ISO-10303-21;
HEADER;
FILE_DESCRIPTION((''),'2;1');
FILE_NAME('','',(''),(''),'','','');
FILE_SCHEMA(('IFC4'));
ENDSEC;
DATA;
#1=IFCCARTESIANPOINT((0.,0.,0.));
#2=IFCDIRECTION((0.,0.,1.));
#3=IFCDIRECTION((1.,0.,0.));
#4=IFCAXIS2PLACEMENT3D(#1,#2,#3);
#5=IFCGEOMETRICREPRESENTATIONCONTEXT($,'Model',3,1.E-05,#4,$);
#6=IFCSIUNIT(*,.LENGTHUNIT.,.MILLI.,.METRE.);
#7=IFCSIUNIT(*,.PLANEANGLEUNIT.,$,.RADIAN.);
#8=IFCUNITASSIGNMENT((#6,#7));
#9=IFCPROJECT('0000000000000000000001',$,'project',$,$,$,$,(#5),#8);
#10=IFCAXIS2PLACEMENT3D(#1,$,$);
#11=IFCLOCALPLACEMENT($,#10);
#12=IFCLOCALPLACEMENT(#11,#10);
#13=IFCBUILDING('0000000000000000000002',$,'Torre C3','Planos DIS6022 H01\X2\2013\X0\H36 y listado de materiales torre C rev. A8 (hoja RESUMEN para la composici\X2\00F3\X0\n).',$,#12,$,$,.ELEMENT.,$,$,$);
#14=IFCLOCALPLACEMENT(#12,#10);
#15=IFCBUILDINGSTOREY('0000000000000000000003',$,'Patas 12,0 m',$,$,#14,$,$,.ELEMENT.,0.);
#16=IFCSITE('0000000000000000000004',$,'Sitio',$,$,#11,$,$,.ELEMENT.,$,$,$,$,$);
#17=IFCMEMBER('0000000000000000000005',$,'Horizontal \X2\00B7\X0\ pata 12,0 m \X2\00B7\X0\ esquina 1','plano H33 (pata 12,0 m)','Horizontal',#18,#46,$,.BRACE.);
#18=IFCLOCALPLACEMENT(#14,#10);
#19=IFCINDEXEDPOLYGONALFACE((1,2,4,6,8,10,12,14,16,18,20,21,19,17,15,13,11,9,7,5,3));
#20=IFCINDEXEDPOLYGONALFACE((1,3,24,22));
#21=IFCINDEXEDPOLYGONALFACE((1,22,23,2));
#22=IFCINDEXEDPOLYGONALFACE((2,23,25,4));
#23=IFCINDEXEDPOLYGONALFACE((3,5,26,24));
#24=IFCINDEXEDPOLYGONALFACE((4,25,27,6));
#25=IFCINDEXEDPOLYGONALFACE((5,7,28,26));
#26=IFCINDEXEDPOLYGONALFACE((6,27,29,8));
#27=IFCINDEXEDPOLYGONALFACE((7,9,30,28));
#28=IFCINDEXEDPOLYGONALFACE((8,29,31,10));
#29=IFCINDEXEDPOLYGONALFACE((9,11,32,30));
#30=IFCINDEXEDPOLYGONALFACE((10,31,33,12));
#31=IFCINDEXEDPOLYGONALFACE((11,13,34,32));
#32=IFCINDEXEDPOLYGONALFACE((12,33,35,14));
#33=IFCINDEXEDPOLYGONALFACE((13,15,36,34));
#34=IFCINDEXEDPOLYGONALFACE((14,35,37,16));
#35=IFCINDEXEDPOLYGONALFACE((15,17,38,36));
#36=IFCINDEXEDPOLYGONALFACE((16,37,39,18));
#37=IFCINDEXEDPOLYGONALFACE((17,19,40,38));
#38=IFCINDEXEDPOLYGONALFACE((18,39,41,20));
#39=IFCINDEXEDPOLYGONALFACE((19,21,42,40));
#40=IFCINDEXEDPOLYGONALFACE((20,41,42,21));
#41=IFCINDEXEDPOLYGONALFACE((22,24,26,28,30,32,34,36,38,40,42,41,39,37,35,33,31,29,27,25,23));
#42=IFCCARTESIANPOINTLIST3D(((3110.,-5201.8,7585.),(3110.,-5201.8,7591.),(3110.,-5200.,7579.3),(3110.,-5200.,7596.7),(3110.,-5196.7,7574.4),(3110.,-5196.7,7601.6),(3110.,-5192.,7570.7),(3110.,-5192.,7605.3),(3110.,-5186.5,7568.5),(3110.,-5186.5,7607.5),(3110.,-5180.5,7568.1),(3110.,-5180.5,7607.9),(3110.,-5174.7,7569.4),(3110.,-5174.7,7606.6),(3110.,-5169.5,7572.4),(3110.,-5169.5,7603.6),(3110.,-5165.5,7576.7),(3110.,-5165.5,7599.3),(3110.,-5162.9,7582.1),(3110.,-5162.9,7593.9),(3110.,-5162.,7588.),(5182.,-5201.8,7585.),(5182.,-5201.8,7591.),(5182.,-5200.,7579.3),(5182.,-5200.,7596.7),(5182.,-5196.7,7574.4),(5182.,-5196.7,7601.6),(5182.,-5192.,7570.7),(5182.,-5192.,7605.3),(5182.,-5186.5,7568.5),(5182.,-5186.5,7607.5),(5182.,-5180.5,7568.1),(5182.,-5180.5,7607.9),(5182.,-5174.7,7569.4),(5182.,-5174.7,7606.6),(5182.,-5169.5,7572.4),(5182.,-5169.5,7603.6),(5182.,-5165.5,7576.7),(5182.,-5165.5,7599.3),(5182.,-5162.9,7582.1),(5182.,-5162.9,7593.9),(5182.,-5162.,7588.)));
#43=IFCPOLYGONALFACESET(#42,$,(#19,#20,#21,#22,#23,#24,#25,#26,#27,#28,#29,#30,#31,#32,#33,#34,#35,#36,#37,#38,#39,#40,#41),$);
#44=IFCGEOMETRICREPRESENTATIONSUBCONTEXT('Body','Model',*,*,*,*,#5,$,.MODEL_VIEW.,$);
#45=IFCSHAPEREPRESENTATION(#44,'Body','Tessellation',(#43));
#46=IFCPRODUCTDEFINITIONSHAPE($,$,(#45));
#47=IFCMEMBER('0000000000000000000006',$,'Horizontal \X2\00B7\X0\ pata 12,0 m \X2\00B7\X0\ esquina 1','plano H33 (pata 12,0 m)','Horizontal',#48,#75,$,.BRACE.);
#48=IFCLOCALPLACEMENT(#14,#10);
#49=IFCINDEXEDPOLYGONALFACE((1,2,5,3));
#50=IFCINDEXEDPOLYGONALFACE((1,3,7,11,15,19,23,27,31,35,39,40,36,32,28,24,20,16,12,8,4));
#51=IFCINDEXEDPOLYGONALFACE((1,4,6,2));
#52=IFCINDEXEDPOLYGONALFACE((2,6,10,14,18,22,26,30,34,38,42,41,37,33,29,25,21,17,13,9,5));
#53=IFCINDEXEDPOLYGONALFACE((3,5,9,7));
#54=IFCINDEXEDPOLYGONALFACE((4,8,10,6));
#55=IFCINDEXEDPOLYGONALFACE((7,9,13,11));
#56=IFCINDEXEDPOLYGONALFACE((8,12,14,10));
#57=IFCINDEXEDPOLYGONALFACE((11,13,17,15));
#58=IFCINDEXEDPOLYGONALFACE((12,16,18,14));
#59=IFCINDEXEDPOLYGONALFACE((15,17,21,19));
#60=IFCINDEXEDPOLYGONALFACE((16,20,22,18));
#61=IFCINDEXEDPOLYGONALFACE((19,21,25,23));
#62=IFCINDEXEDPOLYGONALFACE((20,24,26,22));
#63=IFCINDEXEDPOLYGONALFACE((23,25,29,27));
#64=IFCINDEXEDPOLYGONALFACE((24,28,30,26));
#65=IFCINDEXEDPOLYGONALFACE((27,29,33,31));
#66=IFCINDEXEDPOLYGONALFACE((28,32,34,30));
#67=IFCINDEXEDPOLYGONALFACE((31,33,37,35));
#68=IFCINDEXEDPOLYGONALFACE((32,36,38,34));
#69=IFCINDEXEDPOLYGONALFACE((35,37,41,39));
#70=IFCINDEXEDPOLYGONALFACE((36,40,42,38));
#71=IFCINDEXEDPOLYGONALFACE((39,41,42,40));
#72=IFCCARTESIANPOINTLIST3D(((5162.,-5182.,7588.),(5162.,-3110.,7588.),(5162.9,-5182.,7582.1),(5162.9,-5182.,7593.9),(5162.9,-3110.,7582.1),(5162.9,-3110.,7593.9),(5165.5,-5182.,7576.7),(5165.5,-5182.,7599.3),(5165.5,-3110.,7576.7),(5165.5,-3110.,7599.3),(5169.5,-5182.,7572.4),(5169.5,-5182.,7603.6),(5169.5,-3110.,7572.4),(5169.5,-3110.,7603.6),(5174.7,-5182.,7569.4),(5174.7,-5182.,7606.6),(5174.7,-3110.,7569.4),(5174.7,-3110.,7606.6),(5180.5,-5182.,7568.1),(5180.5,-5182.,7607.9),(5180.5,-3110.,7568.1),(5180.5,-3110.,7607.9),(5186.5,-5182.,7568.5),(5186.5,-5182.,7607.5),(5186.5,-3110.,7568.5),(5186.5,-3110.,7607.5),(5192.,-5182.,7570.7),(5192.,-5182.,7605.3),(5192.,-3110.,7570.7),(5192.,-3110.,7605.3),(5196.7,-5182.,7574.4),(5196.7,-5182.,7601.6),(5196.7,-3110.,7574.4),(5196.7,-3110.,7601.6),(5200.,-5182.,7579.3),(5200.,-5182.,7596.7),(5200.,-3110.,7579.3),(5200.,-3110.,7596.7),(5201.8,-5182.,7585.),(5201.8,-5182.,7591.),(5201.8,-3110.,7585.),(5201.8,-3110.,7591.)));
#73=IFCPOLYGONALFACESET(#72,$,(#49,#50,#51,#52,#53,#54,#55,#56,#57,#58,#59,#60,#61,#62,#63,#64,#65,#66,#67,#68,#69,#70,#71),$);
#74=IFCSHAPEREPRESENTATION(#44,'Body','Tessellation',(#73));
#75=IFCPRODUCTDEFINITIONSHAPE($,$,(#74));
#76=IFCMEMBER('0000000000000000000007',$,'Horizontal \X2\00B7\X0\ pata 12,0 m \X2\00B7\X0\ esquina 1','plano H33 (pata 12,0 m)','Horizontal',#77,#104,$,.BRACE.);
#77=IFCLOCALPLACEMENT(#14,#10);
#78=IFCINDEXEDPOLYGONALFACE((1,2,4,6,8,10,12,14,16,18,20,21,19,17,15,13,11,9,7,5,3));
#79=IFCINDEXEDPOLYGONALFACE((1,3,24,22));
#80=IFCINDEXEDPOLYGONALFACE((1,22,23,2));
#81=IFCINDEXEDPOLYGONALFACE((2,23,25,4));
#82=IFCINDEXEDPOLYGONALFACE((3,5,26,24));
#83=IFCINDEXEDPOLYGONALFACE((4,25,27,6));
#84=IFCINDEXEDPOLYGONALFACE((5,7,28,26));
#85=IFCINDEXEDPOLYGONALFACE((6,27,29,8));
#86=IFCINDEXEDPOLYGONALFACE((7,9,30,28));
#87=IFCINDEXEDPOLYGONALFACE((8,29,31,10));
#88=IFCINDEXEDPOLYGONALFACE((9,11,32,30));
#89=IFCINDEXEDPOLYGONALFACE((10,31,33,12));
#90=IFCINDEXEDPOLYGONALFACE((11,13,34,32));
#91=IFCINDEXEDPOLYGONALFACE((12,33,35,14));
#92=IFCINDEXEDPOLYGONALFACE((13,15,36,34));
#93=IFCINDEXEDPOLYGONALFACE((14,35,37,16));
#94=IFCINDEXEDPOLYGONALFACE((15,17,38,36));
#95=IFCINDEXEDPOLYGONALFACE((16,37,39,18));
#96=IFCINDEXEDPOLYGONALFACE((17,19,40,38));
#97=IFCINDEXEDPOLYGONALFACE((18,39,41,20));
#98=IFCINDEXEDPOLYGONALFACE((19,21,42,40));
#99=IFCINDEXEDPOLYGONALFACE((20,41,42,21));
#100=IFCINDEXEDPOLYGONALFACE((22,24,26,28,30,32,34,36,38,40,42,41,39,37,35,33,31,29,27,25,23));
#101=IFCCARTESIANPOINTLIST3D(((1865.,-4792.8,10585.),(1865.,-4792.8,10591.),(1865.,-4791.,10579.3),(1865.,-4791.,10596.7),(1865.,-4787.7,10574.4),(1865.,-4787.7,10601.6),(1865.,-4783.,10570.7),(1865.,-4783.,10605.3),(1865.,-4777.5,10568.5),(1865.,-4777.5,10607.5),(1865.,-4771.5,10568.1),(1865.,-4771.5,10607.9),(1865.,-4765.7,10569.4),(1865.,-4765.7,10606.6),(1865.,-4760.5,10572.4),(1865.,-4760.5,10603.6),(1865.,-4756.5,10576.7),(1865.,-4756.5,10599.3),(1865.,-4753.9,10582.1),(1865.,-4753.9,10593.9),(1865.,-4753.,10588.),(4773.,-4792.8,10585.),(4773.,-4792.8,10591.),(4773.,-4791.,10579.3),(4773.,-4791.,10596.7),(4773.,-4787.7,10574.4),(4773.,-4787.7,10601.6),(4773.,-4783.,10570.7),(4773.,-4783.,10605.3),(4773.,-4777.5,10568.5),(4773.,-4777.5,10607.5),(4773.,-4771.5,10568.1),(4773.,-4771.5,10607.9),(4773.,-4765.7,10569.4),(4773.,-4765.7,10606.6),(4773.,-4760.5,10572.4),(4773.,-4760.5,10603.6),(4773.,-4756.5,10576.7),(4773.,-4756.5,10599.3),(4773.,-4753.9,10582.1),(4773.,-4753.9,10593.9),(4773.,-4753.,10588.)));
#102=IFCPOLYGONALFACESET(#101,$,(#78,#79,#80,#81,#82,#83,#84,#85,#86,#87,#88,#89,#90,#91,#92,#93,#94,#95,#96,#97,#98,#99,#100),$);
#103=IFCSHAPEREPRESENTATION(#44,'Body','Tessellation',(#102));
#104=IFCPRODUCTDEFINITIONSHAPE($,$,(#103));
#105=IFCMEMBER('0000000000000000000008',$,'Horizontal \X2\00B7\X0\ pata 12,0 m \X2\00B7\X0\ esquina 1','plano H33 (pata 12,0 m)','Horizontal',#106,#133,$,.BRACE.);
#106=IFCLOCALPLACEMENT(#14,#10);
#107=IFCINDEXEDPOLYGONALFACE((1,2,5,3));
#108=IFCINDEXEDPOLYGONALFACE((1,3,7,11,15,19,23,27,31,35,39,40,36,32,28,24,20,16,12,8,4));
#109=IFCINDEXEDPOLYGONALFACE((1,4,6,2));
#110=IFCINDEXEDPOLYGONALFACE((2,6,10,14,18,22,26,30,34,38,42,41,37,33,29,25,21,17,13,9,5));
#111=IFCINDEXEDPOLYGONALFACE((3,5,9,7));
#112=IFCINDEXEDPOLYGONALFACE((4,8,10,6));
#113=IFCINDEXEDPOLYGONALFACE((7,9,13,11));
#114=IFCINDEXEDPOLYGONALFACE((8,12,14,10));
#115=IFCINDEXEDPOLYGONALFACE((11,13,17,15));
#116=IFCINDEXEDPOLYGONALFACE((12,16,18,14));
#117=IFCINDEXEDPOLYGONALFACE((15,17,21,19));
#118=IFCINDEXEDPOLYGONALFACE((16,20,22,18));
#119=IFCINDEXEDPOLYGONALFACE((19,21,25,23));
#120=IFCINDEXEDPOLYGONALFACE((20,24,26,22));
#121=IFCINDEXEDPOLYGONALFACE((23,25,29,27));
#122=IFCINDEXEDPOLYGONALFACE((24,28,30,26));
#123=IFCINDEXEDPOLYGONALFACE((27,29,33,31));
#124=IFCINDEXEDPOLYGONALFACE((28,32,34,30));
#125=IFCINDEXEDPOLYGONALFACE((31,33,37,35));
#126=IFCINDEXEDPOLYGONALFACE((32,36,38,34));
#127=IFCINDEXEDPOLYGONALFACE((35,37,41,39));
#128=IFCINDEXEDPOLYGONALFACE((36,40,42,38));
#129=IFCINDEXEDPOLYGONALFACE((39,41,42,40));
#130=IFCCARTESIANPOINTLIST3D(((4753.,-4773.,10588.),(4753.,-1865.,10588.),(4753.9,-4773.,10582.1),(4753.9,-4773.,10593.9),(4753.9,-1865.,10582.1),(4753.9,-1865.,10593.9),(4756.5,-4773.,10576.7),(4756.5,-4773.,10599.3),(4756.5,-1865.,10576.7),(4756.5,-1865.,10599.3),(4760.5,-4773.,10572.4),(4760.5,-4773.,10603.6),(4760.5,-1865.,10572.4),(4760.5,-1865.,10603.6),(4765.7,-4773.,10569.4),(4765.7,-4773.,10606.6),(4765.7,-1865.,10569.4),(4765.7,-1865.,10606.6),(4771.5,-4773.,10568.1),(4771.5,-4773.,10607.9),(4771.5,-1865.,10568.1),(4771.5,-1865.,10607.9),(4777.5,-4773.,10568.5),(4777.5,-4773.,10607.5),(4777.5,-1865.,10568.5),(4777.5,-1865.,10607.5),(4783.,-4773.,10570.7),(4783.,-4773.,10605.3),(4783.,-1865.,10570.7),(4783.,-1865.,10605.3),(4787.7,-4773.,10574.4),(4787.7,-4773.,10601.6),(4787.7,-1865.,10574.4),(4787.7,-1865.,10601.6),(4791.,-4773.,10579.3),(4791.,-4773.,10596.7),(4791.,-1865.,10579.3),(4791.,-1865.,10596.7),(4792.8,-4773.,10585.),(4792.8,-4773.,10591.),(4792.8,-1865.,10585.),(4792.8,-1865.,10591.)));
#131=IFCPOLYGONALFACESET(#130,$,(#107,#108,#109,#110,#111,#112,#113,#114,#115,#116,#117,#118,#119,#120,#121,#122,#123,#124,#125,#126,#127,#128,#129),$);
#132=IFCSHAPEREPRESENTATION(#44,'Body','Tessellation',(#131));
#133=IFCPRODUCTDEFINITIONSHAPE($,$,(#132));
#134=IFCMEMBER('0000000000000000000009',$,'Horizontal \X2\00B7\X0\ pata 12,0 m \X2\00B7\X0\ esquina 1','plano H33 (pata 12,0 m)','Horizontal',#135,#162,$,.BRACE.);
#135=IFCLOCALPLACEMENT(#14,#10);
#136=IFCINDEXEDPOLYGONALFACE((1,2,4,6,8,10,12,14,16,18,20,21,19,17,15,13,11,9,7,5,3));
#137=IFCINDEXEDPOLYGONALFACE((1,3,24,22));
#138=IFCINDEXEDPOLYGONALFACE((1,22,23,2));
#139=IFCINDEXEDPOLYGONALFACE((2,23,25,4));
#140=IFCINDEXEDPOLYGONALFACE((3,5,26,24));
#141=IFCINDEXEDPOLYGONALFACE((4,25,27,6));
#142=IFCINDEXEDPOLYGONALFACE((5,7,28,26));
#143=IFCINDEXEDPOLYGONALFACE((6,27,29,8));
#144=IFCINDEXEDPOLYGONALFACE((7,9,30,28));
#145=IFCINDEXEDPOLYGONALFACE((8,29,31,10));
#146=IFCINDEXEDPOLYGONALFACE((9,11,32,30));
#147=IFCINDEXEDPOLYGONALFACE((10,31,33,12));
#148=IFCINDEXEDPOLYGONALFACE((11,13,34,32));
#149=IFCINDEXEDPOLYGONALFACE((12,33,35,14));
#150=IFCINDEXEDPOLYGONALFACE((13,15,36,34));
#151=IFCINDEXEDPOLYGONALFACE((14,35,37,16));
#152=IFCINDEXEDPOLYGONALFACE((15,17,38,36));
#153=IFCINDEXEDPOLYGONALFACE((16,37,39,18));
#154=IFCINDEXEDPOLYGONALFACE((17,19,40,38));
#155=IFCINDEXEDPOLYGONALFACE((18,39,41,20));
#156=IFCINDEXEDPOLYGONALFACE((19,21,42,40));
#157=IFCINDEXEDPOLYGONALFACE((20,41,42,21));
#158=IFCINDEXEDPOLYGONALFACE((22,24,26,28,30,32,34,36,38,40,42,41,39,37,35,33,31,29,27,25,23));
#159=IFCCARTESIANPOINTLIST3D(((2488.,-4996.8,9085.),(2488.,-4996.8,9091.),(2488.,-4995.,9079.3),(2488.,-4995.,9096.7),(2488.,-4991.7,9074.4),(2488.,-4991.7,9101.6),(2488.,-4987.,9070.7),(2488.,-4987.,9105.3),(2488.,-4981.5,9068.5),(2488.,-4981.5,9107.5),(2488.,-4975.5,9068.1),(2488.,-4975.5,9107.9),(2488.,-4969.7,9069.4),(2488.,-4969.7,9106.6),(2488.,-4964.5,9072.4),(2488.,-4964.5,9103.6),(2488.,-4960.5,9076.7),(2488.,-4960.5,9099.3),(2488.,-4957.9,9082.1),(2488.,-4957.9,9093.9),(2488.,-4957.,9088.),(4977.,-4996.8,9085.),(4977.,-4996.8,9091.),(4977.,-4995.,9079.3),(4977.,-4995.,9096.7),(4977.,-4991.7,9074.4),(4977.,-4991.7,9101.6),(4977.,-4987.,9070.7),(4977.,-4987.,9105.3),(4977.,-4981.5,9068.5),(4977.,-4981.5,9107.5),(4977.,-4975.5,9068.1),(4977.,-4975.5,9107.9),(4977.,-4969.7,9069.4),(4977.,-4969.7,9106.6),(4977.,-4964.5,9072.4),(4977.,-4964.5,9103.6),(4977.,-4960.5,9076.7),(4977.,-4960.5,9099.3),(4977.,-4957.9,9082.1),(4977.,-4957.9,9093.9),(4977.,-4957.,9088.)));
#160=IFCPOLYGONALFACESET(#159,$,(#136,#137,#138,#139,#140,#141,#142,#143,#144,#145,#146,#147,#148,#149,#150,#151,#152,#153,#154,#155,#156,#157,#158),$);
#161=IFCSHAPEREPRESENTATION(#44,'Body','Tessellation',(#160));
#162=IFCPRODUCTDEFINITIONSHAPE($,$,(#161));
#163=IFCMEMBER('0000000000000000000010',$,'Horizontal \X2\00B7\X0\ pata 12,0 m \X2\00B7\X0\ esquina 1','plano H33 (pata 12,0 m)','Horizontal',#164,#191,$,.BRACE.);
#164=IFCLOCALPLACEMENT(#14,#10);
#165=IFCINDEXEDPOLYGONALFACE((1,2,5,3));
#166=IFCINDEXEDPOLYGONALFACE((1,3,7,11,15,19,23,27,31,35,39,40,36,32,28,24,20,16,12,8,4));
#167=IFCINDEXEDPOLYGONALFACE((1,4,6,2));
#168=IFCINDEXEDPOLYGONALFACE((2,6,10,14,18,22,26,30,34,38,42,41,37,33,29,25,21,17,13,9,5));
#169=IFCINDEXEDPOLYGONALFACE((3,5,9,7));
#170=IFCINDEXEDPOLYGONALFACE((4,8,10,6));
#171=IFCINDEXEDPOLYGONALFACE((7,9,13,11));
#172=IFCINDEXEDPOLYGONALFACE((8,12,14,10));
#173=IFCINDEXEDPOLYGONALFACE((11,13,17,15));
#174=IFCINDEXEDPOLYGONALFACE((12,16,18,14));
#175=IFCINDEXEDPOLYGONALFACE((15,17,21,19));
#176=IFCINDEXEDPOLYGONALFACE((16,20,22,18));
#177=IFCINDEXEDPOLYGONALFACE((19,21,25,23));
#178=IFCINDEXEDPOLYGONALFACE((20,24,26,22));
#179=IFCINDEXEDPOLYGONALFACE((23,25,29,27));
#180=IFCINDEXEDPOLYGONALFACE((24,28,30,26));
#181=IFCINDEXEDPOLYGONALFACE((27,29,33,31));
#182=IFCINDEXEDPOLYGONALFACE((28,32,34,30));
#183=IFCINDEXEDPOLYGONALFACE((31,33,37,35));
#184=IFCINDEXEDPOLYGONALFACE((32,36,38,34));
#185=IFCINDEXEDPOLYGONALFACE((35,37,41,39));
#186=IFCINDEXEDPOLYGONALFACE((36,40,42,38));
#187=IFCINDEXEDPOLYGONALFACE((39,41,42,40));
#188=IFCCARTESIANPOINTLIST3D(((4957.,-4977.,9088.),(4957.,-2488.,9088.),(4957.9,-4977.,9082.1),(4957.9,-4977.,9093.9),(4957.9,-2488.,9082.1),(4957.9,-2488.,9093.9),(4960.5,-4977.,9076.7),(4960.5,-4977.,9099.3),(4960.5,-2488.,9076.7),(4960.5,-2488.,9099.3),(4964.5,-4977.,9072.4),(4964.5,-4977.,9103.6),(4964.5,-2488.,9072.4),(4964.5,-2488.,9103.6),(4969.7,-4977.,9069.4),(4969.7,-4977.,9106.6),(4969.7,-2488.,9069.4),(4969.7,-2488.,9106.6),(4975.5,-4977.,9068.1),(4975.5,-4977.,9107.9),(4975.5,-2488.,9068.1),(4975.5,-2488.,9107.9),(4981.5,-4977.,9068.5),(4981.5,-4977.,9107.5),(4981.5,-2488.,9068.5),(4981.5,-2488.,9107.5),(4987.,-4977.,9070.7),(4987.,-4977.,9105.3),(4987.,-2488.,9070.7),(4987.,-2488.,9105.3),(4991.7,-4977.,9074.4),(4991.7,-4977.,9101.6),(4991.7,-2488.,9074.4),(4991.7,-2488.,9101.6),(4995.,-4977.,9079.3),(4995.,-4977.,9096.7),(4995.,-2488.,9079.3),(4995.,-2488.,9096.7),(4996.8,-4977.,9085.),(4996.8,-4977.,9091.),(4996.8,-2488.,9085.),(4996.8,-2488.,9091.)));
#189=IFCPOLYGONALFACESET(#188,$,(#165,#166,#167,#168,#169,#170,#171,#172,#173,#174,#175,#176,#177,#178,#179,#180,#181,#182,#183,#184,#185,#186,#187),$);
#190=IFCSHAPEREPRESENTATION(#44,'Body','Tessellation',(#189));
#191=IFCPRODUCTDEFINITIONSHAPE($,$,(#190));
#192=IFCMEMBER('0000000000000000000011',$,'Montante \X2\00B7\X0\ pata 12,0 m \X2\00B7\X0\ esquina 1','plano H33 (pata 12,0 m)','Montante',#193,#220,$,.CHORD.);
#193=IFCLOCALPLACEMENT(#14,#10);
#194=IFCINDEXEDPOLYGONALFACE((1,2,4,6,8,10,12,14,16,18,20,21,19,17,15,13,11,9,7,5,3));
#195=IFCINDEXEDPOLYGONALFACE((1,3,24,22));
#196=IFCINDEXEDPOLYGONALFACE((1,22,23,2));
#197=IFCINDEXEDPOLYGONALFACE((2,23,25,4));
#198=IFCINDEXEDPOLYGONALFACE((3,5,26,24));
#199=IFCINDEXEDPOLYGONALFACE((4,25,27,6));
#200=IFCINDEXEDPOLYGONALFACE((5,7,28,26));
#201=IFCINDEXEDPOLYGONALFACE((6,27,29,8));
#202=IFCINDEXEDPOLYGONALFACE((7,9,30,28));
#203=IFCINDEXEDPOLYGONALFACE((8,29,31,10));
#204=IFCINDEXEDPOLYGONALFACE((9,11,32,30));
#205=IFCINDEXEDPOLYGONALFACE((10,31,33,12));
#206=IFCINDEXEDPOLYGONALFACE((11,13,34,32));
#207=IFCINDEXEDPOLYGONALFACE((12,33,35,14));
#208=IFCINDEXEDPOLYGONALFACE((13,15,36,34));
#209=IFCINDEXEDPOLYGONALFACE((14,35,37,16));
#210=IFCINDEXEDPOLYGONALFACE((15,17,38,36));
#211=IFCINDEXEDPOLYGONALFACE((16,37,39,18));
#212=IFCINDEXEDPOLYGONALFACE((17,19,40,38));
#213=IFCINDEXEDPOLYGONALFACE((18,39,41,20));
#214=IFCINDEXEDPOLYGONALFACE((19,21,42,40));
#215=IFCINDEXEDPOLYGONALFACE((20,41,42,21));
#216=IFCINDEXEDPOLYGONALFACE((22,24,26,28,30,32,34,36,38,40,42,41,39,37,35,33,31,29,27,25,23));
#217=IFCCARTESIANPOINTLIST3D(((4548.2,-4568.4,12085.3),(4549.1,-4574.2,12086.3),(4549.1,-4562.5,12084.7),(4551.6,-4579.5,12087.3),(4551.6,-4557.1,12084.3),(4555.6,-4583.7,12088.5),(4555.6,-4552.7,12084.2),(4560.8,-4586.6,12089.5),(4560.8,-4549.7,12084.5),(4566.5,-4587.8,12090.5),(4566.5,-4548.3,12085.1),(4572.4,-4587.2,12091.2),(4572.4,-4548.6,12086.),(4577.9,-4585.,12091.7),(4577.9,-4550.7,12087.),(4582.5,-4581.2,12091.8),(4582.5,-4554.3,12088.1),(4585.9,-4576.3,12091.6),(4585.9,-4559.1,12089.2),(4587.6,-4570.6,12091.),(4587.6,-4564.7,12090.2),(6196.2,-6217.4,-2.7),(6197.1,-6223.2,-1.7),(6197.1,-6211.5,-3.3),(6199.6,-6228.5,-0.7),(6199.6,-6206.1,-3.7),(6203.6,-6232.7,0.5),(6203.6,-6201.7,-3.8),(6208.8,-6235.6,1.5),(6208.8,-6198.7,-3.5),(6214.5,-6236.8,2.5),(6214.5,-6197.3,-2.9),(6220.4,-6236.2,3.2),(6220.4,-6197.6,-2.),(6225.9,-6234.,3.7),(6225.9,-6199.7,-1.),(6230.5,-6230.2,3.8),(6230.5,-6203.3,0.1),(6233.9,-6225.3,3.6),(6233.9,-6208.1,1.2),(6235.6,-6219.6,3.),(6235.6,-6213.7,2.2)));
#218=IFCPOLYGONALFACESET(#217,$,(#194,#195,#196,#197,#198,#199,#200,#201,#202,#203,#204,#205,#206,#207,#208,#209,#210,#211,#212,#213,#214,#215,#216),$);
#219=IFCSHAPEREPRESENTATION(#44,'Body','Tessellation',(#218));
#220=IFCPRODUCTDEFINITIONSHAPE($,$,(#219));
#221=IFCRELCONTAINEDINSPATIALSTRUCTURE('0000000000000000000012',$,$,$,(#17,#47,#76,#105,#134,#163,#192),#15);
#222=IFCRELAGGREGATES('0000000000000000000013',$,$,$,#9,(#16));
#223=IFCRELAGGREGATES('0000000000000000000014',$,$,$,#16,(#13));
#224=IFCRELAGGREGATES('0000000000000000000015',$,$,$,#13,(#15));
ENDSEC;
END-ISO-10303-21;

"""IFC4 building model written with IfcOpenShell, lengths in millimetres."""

from ifc_helpers import new_model, si_unit, frame, origin, origin_with_axes, place, context, subcontext, project, spatial, circle, extrude, element, save


model = new_model("IFC4")

# Units and contexts
model_context = context("Model", 3, precision=1e-05, world=origin_with_axes())
body_context = subcontext(model_context, "Body", "Model", "MODEL_VIEW")
ifc_project = project(units=[si_unit("LENGTHUNIT", "METRE", prefix="MILLI"), si_unit("PLANEANGLEUNIT", "RADIAN")], contexts=[model_context])

# Site, building, storey
site_placement = place(None, origin())
site = spatial("IfcSite", under=ifc_project, at=site_placement, Name="Sitio", CompositionType="ELEMENT")
building_placement = place(site_placement, origin())
building = spatial("IfcBuilding", under=site, at=building_placement, Name="Torre C3", Description="Planos DIS6022 H01–H36 y listado de materiales torre C rev. A8 (hoja RESUMEN para la composición).", CompositionType="ELEMENT")
storey_placement = place(building_placement, origin())
storey = spatial("IfcBuildingStorey", under=building, at=storey_placement, Name="Patas 12,0 m", CompositionType="ELEMENT", Elevation=0.0)

# Members
for number, where, z_axis, x_axis, name in (
    (1, (3110.0, -5182.0, 7588.0), (1.0, 0.0, 0.0), (0.0, 1.0, 0.0), "Horizontal · pata 12,0 m · esquina 1"),
    (2, (5182.0, -3110.0, 7588.0), (0.0, -1.0, 0.0), (-1.0, 0.0, 0.0), "Horizontal · pata 12,0 m · esquina 1"),
):
    element("IfcMember", number, at=place(storey_placement, frame(where, z_axis=z_axis, x_axis=x_axis)), inside=storey, Name=name, Description="plano H33 (pata 12,0 m)", ObjectType="Horizontal", PredefinedType="BRACE", context=body_context, shape_type="SweptSolid", body=[
        extrude(circle(Radius=20.0), None, (0.0, 0.0, 1.0), 2072.0),
    ])
for number, where, z_axis, x_axis, name in (
    (3, (4773.0, -4773.0, 10588.0), (-1.0, 0.0, 0.0), (0.0, 1.0, 0.0), "Horizontal · pata 12,0 m · esquina 1"),
    (4, (4773.0, -4773.0, 10588.0), (0.0, 1.0, 0.0), (-1.0, 0.0, 0.0), "Horizontal · pata 12,0 m · esquina 1"),
):
    element("IfcMember", number, at=place(storey_placement, frame(where, z_axis=z_axis, x_axis=x_axis)), inside=storey, Name=name, Description="plano H33 (pata 12,0 m)", ObjectType="Horizontal", PredefinedType="BRACE", context=body_context, shape_type="SweptSolid", body=[
        extrude(circle(Radius=20.0), None, (0.0, 0.0, 1.0), 2908.0),
    ])
for number, where, z_axis, x_axis, name in (
    (5, (4977.0, -4977.0, 9088.0), (-1.0, 0.0, 0.0), (0.0, 1.0, 0.0), "Horizontal · pata 12,0 m · esquina 1"),
    (6, (4977.0, -4977.0, 9088.0), (0.0, 1.0, 0.0), (-1.0, 0.0, 0.0), "Horizontal · pata 12,0 m · esquina 1"),
):
    element("IfcMember", number, at=place(storey_placement, frame(where, z_axis=z_axis, x_axis=x_axis)), inside=storey, Name=name, Description="plano H33 (pata 12,0 m)", ObjectType="Horizontal", PredefinedType="BRACE", context=body_context, shape_type="SweptSolid", body=[
        extrude(circle(Radius=20.0), None, (0.0, 0.0, 1.0), 2489.0),
    ])
member_1_placement = place(storey_placement, frame((4568.0, -4568.0, 12088.0), z_axis=(0.133867, -0.133948, -0.981905), x_axis=(-0.990999, -0.018094, -0.132638)))
element("IfcMember", 7, at=member_1_placement, inside=storey, Name="Montante · pata 12,0 m · esquina 1", Description="plano H33 (pata 12,0 m)", ObjectType="Montante", PredefinedType="CHORD", context=body_context, shape_type="SweptSolid", body=[
    extrude(circle(Radius=20.0), None, (0.0, 0.0, 1.0), 12310.8),
])

save(model, "model.ifc")
